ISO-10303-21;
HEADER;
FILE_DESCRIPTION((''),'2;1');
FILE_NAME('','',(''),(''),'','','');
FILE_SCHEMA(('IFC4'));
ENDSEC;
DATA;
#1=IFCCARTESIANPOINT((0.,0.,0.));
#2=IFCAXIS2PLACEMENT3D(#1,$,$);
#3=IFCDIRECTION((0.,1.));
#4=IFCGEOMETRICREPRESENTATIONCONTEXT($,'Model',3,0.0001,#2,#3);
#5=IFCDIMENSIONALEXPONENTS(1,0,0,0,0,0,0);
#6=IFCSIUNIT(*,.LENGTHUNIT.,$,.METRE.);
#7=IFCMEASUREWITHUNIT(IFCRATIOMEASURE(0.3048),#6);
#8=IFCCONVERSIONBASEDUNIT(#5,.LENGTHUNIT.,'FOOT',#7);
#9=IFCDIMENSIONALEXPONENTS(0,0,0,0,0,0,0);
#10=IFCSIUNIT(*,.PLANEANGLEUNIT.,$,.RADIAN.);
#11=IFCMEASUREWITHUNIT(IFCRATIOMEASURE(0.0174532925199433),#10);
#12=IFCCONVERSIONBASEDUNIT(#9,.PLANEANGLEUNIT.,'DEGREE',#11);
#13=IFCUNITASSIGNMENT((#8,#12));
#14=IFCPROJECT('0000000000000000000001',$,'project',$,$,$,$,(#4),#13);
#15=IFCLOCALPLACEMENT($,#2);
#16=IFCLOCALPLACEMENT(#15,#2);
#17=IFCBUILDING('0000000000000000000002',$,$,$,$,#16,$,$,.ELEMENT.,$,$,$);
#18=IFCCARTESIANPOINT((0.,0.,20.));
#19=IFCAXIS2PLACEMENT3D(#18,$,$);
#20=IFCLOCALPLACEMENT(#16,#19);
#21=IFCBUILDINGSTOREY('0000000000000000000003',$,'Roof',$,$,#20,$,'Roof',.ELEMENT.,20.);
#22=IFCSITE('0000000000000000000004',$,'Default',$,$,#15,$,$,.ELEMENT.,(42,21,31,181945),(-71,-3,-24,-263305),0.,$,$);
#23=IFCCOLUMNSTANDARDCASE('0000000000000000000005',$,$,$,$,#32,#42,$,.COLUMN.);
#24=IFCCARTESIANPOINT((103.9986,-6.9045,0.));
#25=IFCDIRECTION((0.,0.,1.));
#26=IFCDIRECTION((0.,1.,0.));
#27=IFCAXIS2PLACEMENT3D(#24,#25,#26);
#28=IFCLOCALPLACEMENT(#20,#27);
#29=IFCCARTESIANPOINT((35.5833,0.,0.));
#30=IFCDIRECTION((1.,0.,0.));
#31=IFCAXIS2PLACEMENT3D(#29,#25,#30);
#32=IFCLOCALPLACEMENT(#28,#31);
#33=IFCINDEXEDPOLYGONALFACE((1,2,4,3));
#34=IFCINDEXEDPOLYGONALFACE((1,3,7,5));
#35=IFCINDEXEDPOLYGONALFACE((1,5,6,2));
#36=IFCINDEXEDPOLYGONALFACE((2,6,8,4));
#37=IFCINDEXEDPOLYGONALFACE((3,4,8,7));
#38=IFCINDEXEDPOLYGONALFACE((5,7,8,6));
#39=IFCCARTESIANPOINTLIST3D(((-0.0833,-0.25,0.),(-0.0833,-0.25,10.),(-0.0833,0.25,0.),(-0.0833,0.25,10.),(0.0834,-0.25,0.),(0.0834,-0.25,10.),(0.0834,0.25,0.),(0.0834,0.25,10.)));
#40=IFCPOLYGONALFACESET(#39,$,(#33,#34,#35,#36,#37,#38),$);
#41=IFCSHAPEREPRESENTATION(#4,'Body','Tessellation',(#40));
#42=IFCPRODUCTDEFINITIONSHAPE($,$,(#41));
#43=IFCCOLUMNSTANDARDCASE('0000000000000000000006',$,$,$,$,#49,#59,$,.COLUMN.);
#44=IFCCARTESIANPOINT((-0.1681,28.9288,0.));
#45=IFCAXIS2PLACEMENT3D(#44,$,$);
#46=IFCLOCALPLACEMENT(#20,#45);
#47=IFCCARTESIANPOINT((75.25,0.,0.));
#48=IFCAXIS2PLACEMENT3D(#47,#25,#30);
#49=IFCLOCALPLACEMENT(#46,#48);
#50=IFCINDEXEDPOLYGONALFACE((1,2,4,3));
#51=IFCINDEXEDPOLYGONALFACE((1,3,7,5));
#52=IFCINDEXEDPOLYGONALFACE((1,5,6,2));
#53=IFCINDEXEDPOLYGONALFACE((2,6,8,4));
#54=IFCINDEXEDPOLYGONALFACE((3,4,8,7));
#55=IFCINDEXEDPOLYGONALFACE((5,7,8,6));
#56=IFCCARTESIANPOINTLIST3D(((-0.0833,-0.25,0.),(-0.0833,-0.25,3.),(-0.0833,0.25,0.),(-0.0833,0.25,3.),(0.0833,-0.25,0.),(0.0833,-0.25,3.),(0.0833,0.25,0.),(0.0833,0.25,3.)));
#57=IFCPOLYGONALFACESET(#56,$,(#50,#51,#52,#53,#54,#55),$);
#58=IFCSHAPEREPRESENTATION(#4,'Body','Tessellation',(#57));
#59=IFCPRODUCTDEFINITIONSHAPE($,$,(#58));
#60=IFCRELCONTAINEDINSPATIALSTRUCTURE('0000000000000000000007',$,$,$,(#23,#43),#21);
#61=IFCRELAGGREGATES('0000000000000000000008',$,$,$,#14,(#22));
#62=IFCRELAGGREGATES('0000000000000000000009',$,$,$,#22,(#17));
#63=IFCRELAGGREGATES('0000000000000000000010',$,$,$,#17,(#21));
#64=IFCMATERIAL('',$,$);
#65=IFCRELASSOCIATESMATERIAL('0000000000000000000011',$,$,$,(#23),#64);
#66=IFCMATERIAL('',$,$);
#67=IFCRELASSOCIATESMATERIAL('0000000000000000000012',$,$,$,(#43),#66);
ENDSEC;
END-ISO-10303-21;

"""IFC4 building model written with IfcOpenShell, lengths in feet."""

from ifc_helpers import new_model, entity, si_unit, converted_unit, direction, frame, origin, place, context, project, spatial, rectangle, extrude, material, element, save


model = new_model("IFC4")

# Units and contexts
model_context = context("Model", 3, precision=0.0001, world=origin(), true_north=direction((0.0, 1.0)))
ifc_project = project(units=[converted_unit("LENGTHUNIT", "FOOT", entity("IfcRatioMeasure", 0.3048), si_unit("LENGTHUNIT", "METRE"), dimensions=[1, 0, 0, 0, 0, 0, 0]), converted_unit("PLANEANGLEUNIT", "DEGREE", entity("IfcRatioMeasure", 0.0174532925199433), si_unit("PLANEANGLEUNIT", "RADIAN"), dimensions=[0, 0, 0, 0, 0, 0, 0])], contexts=[model_context])

# Site, building, storey
site_placement = place(None, origin())
site = spatial("IfcSite", under=ifc_project, at=site_placement, Name="Default", CompositionType="ELEMENT", RefLatitude=(42, 21, 31, 181945), RefLongitude=(-71, -3, -24, -263305), RefElevation=0.0)
building_placement = place(site_placement, origin())
building = spatial("IfcBuilding", under=site, at=building_placement, CompositionType="ELEMENT")
storey_placement = place(building_placement, frame((0.0, 0.0, 20.0)))
storey = spatial("IfcBuildingStorey", under=building, at=storey_placement, Name="Roof", LongName="Roof", CompositionType="ELEMENT", Elevation=20.0)

# Columns
ifc_material_1 = material(Name="")
placement_1 = place(storey_placement, frame((103.9986, -6.9045, 0.0), z_axis=(0.0, 0.0, 1.0), x_axis=(0.0, 1.0, 0.0)))
for number, where, z_axis, x_axis in (
    (1, (35.5833, 0.0, 0.0), (0.0, 0.0, 1.0), (1.0, 0.0, 0.0)),
):
    element("IfcColumnStandardCase", number, at=place(placement_1, frame(where, z_axis=z_axis, x_axis=x_axis)), inside=storey, material=ifc_material_1, PredefinedType="COLUMN", context=model_context, shape_type="SweptSolid", body=[
        extrude(rectangle(XDim=0.1667, YDim=0.5), origin(), (0.0, 0.0, 1.0), 10.0),
    ])
ifc_material_2 = material(Name="")
placement_2 = place(storey_placement, frame((-0.1681, 28.9288, 0.0)))
for number, where, z_axis, x_axis in (
    (2, (75.25, 0.0, 0.0), (0.0, 0.0, 1.0), (1.0, 0.0, 0.0)),
):
    element("IfcColumnStandardCase", number, at=place(placement_2, frame(where, z_axis=z_axis, x_axis=x_axis)), inside=storey, material=ifc_material_2, PredefinedType="COLUMN", context=model_context, shape_type="SweptSolid", body=[
        extrude(rectangle(XDim=0.1667, YDim=0.5), origin(), (0.0, 0.0, 1.0), 3.0),
    ])

save(model, "model.ifc")
